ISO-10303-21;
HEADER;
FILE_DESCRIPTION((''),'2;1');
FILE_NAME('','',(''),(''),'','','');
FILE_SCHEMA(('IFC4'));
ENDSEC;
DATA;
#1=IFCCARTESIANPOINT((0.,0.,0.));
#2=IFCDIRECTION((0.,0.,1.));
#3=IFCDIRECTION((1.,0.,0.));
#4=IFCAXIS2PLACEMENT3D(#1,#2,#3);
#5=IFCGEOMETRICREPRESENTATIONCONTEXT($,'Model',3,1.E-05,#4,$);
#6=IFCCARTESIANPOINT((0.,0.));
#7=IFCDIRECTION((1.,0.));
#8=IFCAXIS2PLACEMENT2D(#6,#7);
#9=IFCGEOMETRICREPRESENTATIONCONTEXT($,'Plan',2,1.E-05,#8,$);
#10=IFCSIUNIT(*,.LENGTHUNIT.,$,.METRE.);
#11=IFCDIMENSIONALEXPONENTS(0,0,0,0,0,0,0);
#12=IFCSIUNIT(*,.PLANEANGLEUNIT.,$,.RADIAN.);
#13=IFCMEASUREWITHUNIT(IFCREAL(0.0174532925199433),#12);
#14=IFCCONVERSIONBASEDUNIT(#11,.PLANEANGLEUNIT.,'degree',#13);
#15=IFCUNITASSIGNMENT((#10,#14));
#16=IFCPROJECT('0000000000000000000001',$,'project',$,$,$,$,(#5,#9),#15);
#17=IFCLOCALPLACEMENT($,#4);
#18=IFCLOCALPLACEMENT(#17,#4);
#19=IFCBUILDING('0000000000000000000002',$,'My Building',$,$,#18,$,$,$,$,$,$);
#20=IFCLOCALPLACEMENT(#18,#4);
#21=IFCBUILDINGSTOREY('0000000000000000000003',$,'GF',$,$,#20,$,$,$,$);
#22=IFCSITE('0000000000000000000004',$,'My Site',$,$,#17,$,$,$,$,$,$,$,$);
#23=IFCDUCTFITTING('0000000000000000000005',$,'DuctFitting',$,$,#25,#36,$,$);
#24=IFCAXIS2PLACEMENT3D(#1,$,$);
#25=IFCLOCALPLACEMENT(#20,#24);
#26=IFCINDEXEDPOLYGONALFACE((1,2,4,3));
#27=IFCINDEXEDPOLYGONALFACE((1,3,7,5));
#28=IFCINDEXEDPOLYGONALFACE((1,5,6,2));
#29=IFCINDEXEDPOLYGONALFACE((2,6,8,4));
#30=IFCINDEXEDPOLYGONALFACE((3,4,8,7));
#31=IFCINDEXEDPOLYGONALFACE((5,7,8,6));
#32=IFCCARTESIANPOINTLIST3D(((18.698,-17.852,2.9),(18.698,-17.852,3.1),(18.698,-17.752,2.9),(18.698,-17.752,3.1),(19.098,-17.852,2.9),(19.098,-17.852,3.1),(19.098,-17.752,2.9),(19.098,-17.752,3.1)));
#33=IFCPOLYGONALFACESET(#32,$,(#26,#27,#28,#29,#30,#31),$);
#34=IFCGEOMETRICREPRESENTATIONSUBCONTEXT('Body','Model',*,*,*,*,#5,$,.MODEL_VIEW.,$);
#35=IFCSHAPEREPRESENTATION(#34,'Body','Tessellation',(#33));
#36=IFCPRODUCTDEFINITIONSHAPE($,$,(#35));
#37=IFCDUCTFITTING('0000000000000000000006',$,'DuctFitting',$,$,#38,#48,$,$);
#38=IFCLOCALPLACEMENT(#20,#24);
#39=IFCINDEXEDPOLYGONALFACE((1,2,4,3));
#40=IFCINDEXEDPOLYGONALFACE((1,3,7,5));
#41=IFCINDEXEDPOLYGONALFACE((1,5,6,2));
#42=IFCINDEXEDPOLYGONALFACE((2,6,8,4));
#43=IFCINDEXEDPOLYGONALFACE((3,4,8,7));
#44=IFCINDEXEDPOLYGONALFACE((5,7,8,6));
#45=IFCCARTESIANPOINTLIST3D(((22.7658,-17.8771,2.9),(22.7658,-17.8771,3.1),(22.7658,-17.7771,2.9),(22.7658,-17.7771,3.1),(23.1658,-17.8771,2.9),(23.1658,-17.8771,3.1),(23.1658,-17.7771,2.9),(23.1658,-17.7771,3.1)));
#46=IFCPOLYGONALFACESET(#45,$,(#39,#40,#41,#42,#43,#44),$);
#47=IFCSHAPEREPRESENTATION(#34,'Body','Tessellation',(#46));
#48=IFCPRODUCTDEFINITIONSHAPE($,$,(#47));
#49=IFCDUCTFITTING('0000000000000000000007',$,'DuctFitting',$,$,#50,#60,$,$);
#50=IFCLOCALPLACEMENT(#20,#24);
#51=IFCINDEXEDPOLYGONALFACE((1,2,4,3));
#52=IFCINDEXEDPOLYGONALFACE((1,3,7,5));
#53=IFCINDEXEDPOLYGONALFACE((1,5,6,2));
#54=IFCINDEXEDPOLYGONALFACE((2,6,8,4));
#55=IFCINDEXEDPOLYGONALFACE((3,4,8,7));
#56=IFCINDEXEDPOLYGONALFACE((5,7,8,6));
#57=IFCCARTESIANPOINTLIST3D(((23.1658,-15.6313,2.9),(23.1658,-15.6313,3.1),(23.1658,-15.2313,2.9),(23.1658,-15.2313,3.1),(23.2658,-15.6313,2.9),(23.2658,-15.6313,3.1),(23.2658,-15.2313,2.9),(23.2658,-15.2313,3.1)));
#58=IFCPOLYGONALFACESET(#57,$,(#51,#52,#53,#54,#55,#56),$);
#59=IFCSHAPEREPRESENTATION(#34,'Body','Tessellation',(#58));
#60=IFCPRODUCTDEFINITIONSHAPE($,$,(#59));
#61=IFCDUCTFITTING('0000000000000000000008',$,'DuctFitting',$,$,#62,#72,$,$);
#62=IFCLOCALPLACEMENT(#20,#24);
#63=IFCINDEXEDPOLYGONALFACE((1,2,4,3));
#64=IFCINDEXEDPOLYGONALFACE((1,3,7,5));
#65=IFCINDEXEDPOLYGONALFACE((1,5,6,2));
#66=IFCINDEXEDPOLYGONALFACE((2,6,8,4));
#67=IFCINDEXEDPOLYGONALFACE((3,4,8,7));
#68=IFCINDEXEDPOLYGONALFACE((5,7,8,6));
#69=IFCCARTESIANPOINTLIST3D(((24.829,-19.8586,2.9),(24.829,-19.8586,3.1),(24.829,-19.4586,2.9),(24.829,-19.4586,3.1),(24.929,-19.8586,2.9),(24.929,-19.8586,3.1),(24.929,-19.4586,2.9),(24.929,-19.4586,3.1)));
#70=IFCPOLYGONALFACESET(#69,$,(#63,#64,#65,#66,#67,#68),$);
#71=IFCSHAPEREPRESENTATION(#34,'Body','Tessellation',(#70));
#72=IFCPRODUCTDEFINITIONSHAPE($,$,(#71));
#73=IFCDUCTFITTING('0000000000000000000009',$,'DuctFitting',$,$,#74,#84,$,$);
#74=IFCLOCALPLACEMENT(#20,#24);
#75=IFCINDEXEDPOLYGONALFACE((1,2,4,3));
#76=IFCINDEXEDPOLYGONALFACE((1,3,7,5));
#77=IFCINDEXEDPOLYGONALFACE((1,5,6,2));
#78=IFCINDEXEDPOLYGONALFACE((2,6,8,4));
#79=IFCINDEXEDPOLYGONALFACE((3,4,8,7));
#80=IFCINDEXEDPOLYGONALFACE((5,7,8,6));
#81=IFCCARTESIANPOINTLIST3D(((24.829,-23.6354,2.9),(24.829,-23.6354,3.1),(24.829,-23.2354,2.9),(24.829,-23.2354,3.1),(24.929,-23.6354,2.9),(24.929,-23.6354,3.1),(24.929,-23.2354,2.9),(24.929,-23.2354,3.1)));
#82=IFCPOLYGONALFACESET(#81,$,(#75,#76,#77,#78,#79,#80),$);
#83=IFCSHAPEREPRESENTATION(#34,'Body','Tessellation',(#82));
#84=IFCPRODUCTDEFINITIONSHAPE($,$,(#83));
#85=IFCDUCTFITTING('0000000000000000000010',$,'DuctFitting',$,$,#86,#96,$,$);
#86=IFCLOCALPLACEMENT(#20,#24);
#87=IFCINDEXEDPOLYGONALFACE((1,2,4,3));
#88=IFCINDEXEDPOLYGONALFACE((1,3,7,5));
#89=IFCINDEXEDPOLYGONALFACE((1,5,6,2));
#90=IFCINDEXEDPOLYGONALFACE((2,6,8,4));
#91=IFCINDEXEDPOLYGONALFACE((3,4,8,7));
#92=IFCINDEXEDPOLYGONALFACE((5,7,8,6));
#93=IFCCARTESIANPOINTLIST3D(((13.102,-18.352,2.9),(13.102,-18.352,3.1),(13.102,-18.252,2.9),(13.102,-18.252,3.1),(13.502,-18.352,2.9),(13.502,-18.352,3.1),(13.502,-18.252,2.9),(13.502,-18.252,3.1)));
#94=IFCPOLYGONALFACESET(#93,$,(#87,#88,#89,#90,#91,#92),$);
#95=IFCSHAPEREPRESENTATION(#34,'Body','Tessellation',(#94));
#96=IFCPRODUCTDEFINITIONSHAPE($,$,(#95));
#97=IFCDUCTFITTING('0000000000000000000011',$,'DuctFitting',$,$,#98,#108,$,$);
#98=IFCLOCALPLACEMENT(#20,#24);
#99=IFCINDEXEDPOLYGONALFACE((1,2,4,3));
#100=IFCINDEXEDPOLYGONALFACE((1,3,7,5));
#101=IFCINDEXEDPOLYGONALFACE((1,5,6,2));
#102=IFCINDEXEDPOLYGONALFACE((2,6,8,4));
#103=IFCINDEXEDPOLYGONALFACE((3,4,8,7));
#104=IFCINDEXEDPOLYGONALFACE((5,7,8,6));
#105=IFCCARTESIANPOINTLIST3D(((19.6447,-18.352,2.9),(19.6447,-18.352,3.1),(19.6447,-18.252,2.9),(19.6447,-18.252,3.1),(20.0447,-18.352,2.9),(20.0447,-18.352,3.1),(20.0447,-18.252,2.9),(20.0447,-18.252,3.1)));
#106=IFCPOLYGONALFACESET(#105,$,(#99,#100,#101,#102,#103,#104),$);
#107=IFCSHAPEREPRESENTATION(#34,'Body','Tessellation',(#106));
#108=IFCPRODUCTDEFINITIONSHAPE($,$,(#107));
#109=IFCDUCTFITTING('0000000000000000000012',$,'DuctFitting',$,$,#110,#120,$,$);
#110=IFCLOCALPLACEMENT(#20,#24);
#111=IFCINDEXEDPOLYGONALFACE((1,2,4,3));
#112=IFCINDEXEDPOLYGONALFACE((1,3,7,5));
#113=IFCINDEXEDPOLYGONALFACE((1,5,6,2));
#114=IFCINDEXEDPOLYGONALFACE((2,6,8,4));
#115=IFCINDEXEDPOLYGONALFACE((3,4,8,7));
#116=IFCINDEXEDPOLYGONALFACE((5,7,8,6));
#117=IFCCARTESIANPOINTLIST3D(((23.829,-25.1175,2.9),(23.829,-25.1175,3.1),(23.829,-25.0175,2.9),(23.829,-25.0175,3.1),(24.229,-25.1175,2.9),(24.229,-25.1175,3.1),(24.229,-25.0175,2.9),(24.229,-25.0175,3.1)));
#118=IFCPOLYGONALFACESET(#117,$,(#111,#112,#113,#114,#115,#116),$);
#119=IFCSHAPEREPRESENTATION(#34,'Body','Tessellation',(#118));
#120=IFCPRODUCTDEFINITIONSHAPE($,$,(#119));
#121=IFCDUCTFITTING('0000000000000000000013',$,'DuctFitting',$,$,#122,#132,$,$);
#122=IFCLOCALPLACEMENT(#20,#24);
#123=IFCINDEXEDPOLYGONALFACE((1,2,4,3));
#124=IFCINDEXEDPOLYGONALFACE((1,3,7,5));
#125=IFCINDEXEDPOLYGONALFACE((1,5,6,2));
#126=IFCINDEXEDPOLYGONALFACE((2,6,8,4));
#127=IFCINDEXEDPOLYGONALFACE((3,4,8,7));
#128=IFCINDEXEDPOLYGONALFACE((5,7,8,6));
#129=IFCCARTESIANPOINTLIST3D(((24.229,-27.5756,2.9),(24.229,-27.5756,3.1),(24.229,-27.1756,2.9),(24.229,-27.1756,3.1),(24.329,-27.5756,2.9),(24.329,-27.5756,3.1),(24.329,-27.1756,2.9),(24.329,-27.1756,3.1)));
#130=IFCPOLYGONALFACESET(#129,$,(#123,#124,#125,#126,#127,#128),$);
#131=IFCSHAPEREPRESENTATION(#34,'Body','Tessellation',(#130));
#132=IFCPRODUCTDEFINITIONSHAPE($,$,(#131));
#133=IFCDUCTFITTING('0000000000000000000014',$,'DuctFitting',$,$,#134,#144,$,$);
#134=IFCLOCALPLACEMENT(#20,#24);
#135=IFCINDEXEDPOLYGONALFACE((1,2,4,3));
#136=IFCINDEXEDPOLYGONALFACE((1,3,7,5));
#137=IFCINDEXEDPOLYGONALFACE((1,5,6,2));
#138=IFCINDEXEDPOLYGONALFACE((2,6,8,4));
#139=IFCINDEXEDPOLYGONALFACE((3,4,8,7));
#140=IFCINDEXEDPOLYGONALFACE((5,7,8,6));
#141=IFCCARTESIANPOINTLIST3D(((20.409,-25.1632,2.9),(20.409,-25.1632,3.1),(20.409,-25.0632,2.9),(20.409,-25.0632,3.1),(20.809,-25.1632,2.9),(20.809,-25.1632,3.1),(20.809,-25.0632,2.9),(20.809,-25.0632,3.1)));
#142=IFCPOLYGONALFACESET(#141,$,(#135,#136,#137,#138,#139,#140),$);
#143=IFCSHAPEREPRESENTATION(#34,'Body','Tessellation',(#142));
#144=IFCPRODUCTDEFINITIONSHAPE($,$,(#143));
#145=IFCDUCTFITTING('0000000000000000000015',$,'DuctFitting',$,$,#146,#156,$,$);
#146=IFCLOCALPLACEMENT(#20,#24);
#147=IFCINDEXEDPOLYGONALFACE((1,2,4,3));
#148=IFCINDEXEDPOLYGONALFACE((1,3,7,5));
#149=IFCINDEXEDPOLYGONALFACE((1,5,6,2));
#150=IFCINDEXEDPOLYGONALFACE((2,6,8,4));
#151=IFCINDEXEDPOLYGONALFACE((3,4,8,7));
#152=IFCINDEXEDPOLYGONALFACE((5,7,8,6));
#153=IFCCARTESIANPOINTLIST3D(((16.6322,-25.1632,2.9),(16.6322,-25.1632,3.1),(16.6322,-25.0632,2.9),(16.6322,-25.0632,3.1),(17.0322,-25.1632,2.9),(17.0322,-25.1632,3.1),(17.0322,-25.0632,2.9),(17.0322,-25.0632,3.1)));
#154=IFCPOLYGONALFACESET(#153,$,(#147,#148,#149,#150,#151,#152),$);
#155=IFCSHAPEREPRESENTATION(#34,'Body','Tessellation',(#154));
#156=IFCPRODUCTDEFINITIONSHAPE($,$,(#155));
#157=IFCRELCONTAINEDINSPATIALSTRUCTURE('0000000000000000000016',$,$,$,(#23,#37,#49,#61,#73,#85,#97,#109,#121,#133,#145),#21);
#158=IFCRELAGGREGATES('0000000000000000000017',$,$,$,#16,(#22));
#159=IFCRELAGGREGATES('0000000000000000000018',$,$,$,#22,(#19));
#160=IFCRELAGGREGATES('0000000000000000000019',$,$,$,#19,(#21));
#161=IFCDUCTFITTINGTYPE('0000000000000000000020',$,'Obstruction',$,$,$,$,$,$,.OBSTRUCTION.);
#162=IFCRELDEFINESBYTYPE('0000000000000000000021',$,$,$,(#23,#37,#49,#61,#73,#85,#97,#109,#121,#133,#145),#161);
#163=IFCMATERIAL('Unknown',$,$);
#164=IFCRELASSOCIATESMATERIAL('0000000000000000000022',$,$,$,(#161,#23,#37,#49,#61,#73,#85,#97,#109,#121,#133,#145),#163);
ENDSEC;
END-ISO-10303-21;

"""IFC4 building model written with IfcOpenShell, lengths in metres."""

from ifc_helpers import new_model, entity, si_unit, converted_unit, frame, origin_with_axes, origin_2d_with_axis, place, context, subcontext, project, spatial, rectangle, extrude, material, material_profile, profile_set, profile_usage, type_object, element, save


model = new_model("IFC4")

# Units and contexts
model_context = context("Model", 3, precision=1e-05, world=origin_with_axes())
plan_context = context("Plan", 2, precision=1e-05, world=origin_2d_with_axis())
body_context_1 = subcontext(model_context, "Body", "Model", "MODEL_VIEW")
ifc_project = project(units=[si_unit("LENGTHUNIT", "METRE"), converted_unit("PLANEANGLEUNIT", "degree", entity("IfcReal", 0.0174532925199433), si_unit("PLANEANGLEUNIT", "RADIAN"), dimensions=[0, 0, 0, 0, 0, 0, 0])], contexts=[model_context, plan_context])

# Site, building, storey
site_placement = place(None, origin_with_axes())
site = spatial("IfcSite", under=ifc_project, at=site_placement, Name="My Site")
building_placement = place(site_placement, origin_with_axes())
building = spatial("IfcBuilding", under=site, at=building_placement, Name="My Building")
storey_placement = place(building_placement, origin_with_axes())
storey = spatial("IfcBuildingStorey", under=building, at=storey_placement, Name="GF")

# Shared definitions
ifc_material = material(Name="Unknown")

# Duct fittings
ifc_material_profile = material_profile(ifc_material, rectangle(XDim=0.4, YDim=0.2))
ifc_profile_set = profile_set([ifc_material_profile])
duct_fitting_type = type_object("IfcDuctFittingType", Name="Obstruction", PredefinedType="OBSTRUCTION", material=ifc_profile_set)
ifc_profile_usage_1 = profile_usage(ifc_profile_set, cardinal=5)
duct_fitting_1_placement = place(storey_placement, frame((18.898, -17.852, 3.0), z_axis=(0.0, 1.0, 0.0), x_axis=(-1.0, 0.0, 0.0)))
element("IfcDuctFitting", 1, at=duct_fitting_1_placement, inside=storey, type_object=duct_fitting_type, material=ifc_profile_usage_1, Name="DuctFitting", context=body_context_1, shape_type="SweptSolid", body=[
    extrude(rectangle(XDim=0.4, YDim=0.2), origin_with_axes(), (0.0, 0.0, 1.0), 0.1),
])
ifc_profile_usage_2 = profile_usage(ifc_profile_set, cardinal=5)
duct_fitting_2_placement = place(storey_placement, frame((22.9658, -17.8771, 3.0), z_axis=(0.0, 1.0, 0.0), x_axis=(-1.0, 0.0, 0.0)))
element("IfcDuctFitting", 2, at=duct_fitting_2_placement, inside=storey, type_object=duct_fitting_type, material=ifc_profile_usage_2, Name="DuctFitting", context=body_context_1, shape_type="SweptSolid", body=[
    extrude(rectangle(XDim=0.4, YDim=0.2), origin_with_axes(), (0.0, 0.0, 1.0), 0.1),
])
ifc_profile_usage_3 = profile_usage(ifc_profile_set, cardinal=5)
duct_fitting_3_placement = place(storey_placement, frame((23.1658, -15.4313, 3.0), z_axis=(1.0, 0.0, 0.0), x_axis=(0.0, 1.0, 0.0)))
element("IfcDuctFitting", 3, at=duct_fitting_3_placement, inside=storey, type_object=duct_fitting_type, material=ifc_profile_usage_3, Name="DuctFitting", context=body_context_1, shape_type="SweptSolid", body=[
    extrude(rectangle(XDim=0.4, YDim=0.2), origin_with_axes(), (0.0, 0.0, 1.0), 0.1),
])
ifc_profile_usage_4 = profile_usage(ifc_profile_set, cardinal=5)
duct_fitting_4_placement = place(storey_placement, frame((24.829, -19.6586, 3.0), z_axis=(1.0, 0.0, 0.0), x_axis=(0.0, 1.0, 0.0)))
element("IfcDuctFitting", 4, at=duct_fitting_4_placement, inside=storey, type_object=duct_fitting_type, material=ifc_profile_usage_4, Name="DuctFitting", context=body_context_1, shape_type="SweptSolid", body=[
    extrude(rectangle(XDim=0.4, YDim=0.2), origin_with_axes(), (0.0, 0.0, 1.0), 0.1),
])
ifc_profile_usage_5 = profile_usage(ifc_profile_set, cardinal=5)
duct_fitting_5_placement = place(storey_placement, frame((24.829, -23.4354, 3.0), z_axis=(1.0, 0.0, 0.0), x_axis=(0.0, 1.0, 0.0)))
element("IfcDuctFitting", 5, at=duct_fitting_5_placement, inside=storey, type_object=duct_fitting_type, material=ifc_profile_usage_5, Name="DuctFitting", context=body_context_1, shape_type="SweptSolid", body=[
    extrude(rectangle(XDim=0.4, YDim=0.2), origin_with_axes(), (0.0, 0.0, 1.0), 0.1),
])
ifc_profile_usage_6 = profile_usage(ifc_profile_set, cardinal=5)
duct_fitting_6_placement = place(storey_placement, frame((13.302, -18.252, 3.0), z_axis=(0.0, -1.0, 0.0), x_axis=(1.0, 0.0, 0.0)))
element("IfcDuctFitting", 6, at=duct_fitting_6_placement, inside=storey, type_object=duct_fitting_type, material=ifc_profile_usage_6, Name="DuctFitting", context=body_context_1, shape_type="SweptSolid", body=[
    extrude(rectangle(XDim=0.4, YDim=0.2), origin_with_axes(), (0.0, 0.0, 1.0), 0.1),
])
ifc_profile_usage_7 = profile_usage(ifc_profile_set, cardinal=5)
duct_fitting_7_placement = place(storey_placement, frame((19.8447, -18.252, 3.0), z_axis=(0.0, -1.0, 0.0), x_axis=(1.0, 0.0, 0.0)))
element("IfcDuctFitting", 7, at=duct_fitting_7_placement, inside=storey, type_object=duct_fitting_type, material=ifc_profile_usage_7, Name="DuctFitting", context=body_context_1, shape_type="SweptSolid", body=[
    extrude(rectangle(XDim=0.4, YDim=0.2), origin_with_axes(), (0.0, 0.0, 1.0), 0.1),
])
ifc_profile_usage_8 = profile_usage(ifc_profile_set, cardinal=5)
duct_fitting_8_placement = place(storey_placement, frame((24.029, -25.0175, 3.0), z_axis=(0.0, -1.0, 0.0), x_axis=(1.0, 0.0, 0.0)))
element("IfcDuctFitting", 8, at=duct_fitting_8_placement, inside=storey, type_object=duct_fitting_type, material=ifc_profile_usage_8, Name="DuctFitting", context=body_context_1, shape_type="SweptSolid", body=[
    extrude(rectangle(XDim=0.4, YDim=0.2), origin_with_axes(), (0.0, 0.0, 1.0), 0.1),
])
ifc_profile_usage_9 = profile_usage(ifc_profile_set, cardinal=5)
duct_fitting_9_placement = place(storey_placement, frame((24.229, -27.3756, 3.0), z_axis=(1.0, 0.0, 0.0), x_axis=(0.0, 1.0, 0.0)))
element("IfcDuctFitting", 9, at=duct_fitting_9_placement, inside=storey, type_object=duct_fitting_type, material=ifc_profile_usage_9, Name="DuctFitting", context=body_context_1, shape_type="SweptSolid", body=[
    extrude(rectangle(XDim=0.4, YDim=0.2), origin_with_axes(), (0.0, 0.0, 1.0), 0.1),
])
ifc_profile_usage_10 = profile_usage(ifc_profile_set, cardinal=5)
duct_fitting_10_placement = place(storey_placement, frame((20.609, -25.0632, 3.0), z_axis=(0.0, -1.0, 0.0), x_axis=(1.0, 0.0, 0.0)))
element("IfcDuctFitting", 10, at=duct_fitting_10_placement, inside=storey, type_object=duct_fitting_type, material=ifc_profile_usage_10, Name="DuctFitting", context=body_context_1, shape_type="SweptSolid", body=[
    extrude(rectangle(XDim=0.4, YDim=0.2), origin_with_axes(), (0.0, 0.0, 1.0), 0.1),
])
ifc_profile_usage_11 = profile_usage(ifc_profile_set, cardinal=5)
duct_fitting_11_placement = place(storey_placement, frame((16.8322, -25.0632, 3.0), z_axis=(0.0, -1.0, 0.0), x_axis=(1.0, 0.0, 0.0)))
element("IfcDuctFitting", 11, at=duct_fitting_11_placement, inside=storey, type_object=duct_fitting_type, material=ifc_profile_usage_11, Name="DuctFitting", context=body_context_1, shape_type="SweptSolid", body=[
    extrude(rectangle(XDim=0.4, YDim=0.2), origin_with_axes(), (0.0, 0.0, 1.0), 0.1),
])

save(model, "model.ifc")
